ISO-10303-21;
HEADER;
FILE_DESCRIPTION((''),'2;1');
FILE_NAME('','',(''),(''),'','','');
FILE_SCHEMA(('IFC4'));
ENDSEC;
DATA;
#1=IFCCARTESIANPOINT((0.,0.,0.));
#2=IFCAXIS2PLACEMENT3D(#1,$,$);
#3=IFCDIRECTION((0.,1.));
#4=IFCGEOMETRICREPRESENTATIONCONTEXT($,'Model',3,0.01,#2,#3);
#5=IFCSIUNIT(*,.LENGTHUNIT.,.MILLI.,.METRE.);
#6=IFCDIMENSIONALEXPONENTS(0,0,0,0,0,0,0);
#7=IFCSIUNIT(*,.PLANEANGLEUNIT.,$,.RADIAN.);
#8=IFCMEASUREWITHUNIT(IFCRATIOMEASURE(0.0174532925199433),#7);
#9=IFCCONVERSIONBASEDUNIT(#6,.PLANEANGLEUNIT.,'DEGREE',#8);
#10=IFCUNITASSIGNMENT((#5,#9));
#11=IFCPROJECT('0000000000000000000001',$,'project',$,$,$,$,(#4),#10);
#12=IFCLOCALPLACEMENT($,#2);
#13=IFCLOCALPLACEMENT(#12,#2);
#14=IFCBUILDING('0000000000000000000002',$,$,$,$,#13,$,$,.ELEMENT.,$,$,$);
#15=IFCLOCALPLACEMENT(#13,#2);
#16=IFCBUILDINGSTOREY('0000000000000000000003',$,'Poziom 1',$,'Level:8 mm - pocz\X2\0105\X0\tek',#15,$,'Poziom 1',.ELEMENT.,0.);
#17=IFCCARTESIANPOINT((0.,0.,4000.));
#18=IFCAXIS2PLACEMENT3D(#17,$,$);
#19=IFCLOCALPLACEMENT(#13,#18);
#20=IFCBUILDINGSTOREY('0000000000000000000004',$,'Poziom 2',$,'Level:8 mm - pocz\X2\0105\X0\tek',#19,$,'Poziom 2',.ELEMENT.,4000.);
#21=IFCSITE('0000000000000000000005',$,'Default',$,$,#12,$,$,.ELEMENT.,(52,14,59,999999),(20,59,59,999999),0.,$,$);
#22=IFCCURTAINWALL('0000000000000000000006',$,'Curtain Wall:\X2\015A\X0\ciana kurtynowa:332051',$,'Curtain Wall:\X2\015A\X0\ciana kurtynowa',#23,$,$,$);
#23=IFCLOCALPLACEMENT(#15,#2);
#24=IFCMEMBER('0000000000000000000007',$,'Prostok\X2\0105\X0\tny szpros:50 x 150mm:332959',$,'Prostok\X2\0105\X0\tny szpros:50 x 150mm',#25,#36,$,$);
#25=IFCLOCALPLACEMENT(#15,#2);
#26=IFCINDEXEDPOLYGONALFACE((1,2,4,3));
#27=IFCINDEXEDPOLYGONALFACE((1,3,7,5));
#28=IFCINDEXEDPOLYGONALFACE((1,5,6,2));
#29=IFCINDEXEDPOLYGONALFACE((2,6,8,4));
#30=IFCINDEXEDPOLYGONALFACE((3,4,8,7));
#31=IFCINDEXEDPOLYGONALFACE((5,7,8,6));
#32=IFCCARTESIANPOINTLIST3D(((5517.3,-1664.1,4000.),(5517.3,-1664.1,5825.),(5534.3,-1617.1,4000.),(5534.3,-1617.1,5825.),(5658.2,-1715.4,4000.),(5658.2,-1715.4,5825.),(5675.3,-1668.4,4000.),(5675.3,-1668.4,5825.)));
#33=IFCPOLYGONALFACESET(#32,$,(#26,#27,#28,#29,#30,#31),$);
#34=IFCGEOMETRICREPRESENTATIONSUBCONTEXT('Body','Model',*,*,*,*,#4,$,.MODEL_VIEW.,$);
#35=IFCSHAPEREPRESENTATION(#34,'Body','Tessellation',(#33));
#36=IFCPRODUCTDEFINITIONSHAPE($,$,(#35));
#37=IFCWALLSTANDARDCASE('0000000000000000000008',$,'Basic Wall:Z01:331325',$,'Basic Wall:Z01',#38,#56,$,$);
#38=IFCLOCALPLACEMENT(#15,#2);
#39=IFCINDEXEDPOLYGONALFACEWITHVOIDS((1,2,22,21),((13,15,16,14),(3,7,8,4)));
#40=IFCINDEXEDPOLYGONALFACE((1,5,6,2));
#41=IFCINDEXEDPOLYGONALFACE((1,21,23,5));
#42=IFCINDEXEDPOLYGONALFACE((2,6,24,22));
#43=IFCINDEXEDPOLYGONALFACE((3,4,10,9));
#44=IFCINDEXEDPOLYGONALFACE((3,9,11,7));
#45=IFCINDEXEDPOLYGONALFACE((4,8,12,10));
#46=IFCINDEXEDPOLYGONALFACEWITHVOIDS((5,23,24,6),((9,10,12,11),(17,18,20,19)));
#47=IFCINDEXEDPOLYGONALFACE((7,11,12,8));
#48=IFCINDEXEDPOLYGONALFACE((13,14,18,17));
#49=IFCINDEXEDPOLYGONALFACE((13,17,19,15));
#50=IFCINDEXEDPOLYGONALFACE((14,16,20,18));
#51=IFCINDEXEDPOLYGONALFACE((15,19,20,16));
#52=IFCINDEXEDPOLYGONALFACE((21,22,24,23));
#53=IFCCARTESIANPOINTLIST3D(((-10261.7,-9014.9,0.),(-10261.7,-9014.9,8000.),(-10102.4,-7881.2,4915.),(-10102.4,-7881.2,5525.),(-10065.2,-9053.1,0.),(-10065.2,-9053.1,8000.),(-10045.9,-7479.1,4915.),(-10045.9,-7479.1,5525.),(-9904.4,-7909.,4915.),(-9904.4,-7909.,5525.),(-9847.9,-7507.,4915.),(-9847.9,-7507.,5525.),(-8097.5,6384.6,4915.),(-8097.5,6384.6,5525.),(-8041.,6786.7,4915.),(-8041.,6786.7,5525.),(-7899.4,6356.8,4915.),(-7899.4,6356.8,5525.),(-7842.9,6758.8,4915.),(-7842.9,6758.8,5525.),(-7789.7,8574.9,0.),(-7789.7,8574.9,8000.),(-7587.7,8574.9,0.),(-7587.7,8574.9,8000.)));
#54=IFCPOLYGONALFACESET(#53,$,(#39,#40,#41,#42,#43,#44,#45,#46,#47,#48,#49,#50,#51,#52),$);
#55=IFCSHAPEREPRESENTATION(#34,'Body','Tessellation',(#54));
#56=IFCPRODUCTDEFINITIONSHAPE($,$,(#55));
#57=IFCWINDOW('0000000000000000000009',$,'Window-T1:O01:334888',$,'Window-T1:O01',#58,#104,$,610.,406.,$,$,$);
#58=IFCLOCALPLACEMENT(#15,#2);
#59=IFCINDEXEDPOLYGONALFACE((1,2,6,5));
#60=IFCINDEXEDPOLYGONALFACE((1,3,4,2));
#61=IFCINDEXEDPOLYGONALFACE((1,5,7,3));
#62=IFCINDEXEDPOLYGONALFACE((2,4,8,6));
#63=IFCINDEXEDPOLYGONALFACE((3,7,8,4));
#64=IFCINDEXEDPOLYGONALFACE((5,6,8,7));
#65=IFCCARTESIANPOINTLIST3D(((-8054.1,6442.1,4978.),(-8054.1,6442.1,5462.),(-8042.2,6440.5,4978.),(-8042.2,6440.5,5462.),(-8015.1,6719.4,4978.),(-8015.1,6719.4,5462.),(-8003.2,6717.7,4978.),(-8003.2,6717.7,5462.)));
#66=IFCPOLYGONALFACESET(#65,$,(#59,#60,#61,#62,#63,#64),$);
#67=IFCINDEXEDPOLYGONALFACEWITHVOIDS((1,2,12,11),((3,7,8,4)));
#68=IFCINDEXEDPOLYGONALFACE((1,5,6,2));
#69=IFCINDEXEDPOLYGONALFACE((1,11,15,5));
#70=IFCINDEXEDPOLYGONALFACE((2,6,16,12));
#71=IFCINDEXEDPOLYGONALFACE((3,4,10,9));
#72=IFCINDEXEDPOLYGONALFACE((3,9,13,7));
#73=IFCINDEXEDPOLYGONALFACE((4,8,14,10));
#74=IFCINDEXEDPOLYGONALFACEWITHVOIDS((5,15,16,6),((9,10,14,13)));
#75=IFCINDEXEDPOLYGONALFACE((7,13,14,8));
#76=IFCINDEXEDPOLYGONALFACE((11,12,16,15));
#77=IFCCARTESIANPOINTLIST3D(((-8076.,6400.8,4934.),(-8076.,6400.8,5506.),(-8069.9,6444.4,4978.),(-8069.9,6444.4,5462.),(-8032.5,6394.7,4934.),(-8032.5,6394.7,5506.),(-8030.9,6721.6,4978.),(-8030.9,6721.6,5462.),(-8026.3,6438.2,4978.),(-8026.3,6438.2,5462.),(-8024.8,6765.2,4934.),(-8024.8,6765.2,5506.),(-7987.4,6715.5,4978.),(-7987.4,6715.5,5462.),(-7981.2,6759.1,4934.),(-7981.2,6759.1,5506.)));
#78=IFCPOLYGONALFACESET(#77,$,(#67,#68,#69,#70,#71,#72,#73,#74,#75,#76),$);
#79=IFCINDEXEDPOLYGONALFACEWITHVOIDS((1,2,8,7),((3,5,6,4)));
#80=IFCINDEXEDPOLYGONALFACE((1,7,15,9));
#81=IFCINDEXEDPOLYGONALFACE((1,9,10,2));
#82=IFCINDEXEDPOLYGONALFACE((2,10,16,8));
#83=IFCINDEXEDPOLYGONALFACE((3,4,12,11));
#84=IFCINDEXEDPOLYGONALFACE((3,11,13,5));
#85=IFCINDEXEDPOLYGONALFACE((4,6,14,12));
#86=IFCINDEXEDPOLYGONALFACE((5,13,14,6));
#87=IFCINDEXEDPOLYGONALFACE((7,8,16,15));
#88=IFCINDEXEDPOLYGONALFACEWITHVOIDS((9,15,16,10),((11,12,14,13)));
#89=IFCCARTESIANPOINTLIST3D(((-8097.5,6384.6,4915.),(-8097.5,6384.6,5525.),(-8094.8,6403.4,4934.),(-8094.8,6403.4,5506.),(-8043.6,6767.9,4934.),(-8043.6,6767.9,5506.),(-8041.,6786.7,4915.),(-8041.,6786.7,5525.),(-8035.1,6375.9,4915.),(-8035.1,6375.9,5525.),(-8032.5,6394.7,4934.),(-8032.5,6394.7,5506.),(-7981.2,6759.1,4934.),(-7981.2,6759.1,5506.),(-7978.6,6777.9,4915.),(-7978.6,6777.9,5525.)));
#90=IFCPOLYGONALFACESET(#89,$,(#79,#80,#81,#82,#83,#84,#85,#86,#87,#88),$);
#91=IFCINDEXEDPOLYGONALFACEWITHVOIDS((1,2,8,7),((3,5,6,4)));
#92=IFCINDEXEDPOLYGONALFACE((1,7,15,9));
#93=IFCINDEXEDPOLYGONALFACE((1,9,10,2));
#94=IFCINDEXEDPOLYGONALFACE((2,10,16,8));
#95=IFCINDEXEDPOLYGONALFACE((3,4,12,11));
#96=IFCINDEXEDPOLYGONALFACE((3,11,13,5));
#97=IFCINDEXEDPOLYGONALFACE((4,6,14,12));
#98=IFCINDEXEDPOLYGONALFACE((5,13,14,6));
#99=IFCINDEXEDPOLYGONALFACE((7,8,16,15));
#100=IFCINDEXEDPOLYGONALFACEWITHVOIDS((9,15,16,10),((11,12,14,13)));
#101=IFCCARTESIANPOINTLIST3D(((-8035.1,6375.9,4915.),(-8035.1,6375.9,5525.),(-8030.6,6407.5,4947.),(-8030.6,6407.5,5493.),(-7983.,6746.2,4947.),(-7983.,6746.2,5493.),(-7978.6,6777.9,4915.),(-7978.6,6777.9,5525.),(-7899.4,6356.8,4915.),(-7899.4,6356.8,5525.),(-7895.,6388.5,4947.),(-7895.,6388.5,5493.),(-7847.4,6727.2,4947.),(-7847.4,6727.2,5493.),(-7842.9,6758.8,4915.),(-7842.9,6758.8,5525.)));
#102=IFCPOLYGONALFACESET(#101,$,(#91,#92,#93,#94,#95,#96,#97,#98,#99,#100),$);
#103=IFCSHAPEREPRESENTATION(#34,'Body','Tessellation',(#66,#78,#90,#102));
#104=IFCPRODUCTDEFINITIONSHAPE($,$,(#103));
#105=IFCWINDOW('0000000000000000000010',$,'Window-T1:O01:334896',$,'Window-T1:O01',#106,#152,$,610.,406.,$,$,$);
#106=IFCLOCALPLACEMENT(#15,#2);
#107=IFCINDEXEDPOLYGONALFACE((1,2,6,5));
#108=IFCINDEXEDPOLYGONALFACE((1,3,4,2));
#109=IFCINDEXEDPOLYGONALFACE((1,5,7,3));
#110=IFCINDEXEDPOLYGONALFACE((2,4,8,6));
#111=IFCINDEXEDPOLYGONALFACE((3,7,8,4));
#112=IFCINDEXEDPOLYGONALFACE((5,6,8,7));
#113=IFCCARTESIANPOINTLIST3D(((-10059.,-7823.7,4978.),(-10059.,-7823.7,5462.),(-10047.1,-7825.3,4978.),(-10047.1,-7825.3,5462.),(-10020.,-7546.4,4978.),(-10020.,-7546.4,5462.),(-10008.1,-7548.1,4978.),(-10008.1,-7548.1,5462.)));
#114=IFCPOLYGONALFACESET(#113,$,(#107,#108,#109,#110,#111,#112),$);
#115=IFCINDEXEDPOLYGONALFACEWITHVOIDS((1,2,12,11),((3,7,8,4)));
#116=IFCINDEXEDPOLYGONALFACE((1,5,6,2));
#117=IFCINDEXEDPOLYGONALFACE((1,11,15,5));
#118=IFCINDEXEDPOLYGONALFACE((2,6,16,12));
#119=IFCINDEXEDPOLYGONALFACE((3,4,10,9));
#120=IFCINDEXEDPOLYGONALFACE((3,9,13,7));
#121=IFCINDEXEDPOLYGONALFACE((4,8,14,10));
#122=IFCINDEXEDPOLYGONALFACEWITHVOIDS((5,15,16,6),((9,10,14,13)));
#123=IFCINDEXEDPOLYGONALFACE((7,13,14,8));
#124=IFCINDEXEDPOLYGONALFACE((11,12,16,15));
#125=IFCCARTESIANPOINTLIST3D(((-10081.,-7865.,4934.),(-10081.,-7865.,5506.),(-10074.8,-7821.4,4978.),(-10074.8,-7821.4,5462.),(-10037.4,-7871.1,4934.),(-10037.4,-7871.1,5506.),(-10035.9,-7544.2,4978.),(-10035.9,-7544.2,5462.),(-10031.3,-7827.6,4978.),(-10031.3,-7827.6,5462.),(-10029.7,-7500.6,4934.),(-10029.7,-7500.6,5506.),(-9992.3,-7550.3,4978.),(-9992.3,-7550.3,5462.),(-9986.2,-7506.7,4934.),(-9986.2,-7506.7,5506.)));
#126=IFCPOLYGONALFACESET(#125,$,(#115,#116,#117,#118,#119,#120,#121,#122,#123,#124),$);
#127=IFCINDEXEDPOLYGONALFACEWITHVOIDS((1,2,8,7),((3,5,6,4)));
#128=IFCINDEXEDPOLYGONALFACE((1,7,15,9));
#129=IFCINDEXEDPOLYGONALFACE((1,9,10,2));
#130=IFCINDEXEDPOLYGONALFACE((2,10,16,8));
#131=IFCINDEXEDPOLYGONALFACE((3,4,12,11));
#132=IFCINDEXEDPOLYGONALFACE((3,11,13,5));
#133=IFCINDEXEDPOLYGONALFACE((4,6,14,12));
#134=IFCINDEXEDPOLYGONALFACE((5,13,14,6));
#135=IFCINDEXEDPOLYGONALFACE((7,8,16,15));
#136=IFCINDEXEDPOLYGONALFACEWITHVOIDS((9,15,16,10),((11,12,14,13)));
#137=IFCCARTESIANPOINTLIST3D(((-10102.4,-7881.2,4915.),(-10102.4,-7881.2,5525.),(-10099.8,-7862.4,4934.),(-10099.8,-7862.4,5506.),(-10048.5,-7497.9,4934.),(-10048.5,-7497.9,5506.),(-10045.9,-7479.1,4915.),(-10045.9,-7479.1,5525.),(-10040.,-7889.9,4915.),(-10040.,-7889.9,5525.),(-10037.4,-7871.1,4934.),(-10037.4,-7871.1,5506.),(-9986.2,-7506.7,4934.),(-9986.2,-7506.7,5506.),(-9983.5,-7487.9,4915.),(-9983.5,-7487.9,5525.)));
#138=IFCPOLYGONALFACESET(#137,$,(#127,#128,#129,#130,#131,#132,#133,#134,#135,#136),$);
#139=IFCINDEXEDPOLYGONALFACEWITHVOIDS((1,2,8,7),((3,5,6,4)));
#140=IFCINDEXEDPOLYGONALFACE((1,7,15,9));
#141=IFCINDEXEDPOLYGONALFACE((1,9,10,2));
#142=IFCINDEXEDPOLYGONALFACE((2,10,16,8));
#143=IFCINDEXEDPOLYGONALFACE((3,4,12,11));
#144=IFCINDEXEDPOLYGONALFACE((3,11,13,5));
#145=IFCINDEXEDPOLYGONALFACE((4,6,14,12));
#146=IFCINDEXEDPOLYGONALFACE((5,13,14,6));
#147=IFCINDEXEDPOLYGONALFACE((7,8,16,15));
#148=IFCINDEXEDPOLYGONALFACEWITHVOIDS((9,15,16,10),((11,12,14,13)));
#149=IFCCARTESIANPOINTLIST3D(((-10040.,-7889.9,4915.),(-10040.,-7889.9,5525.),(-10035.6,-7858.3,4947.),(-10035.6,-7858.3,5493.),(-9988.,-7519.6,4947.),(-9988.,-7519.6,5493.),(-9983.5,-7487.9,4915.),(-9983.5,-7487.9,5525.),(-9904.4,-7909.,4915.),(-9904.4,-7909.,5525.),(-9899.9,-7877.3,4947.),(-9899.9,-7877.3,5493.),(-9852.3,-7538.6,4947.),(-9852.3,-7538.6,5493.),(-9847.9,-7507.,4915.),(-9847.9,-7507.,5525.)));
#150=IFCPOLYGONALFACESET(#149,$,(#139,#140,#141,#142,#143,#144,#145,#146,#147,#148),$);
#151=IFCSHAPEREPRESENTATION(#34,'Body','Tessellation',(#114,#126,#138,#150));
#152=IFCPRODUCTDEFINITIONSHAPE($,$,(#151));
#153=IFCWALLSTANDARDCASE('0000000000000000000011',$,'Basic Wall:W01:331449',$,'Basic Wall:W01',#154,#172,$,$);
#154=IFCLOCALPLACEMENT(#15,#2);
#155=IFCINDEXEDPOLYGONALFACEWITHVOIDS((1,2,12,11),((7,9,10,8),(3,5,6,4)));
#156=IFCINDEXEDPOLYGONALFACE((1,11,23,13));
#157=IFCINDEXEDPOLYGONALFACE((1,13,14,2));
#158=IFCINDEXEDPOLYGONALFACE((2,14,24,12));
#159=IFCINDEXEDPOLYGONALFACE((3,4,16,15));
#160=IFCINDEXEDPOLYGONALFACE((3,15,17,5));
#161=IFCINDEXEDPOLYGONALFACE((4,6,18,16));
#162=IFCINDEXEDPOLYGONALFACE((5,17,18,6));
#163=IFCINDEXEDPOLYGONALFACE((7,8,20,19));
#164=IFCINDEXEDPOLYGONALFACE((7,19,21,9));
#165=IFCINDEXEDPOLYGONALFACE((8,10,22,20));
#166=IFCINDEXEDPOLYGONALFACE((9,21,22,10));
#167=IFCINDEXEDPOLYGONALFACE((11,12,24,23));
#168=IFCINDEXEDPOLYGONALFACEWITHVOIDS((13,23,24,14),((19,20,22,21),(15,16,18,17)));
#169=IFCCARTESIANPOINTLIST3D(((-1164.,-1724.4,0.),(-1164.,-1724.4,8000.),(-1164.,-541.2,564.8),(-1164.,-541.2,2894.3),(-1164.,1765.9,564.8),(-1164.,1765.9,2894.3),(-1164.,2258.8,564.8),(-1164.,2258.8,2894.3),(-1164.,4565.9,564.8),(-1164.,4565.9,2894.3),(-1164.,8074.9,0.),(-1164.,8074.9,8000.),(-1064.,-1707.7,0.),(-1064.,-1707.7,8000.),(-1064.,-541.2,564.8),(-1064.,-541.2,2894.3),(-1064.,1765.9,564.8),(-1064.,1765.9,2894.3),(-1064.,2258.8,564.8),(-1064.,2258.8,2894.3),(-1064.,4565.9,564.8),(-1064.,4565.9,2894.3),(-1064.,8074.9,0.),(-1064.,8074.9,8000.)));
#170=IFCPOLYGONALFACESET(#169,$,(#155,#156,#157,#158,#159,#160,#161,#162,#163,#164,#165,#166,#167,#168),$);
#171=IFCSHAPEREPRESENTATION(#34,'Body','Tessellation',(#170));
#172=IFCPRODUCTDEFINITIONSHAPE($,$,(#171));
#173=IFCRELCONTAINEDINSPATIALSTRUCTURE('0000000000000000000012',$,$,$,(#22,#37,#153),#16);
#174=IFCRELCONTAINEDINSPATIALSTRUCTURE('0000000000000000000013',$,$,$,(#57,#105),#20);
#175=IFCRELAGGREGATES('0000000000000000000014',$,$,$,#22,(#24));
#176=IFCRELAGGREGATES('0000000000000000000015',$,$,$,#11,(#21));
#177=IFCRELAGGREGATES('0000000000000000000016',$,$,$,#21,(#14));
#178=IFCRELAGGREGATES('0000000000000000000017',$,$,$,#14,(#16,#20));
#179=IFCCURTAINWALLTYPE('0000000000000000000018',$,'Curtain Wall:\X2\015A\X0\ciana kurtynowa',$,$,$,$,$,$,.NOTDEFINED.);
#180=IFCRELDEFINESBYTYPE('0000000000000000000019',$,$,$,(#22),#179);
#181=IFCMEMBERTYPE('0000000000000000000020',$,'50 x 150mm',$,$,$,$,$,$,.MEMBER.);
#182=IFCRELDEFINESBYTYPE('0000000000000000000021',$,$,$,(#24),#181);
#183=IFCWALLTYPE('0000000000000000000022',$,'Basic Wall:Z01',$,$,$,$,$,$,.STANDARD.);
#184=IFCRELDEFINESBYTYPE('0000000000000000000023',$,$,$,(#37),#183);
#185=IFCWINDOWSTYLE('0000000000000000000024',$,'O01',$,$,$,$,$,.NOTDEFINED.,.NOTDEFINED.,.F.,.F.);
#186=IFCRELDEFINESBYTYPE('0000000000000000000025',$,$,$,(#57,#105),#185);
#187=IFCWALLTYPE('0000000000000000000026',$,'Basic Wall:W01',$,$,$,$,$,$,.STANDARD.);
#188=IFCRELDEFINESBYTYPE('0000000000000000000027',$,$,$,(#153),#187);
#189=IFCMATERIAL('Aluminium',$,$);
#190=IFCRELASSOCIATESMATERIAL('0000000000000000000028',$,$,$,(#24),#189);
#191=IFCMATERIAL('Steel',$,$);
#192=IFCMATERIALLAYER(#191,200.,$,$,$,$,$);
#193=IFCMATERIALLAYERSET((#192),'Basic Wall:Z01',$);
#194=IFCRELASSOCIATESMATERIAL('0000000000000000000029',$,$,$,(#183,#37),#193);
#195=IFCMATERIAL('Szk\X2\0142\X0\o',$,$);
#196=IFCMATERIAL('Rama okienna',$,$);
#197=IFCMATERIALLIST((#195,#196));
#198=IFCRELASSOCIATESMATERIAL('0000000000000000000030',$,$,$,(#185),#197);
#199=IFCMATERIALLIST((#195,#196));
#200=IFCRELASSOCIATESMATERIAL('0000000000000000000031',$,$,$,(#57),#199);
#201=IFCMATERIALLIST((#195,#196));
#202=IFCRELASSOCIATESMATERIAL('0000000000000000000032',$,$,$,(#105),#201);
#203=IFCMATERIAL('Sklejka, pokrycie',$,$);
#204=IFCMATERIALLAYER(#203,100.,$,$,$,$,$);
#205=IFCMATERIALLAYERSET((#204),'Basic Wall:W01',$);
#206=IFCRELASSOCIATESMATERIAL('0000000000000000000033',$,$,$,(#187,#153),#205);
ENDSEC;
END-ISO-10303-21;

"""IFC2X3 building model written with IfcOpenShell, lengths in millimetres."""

from ifc_helpers import new_model, entity, si_unit, converted_unit, direction, frame, frame_2d, origin, origin_2d_with_axis, place, context, subcontext, project, spatial, polyline, rectangle, outline, extrude, source, transform, mapped, material, material_list, layer, layer_set, layer_usage, type_object, type_shapes, element, fill, aggregate, save


model = new_model("IFC2X3")

# Units and contexts
model_context = context("Model", 3, precision=0.01, world=origin(), true_north=direction((0.0, 1.0)))
body_context = subcontext(model_context, "Body", "Model", "MODEL_VIEW")
ifc_project = project(units=[si_unit("LENGTHUNIT", "METRE", prefix="MILLI"), converted_unit("PLANEANGLEUNIT", "DEGREE", entity("IfcRatioMeasure", 0.0174532925199433), si_unit("PLANEANGLEUNIT", "RADIAN"), dimensions=[0, 0, 0, 0, 0, 0, 0])], contexts=[model_context])

# Site, building, storey
site_placement = place(None, origin())
site = spatial("IfcSite", under=ifc_project, at=site_placement, Name="Default", CompositionType="ELEMENT", RefLatitude=(52, 14, 59, 999999), RefLongitude=(20, 59, 59, 999999), RefElevation=0.0)
building_placement = place(site_placement, origin())
building = spatial("IfcBuilding", under=site, at=building_placement, CompositionType="ELEMENT")
storey_1_placement = place(building_placement, origin())
storey_1 = spatial("IfcBuildingStorey", under=building, at=storey_1_placement, Name="Poziom 1", ObjectType="Level:8 mm - początek", LongName="Poziom 1", CompositionType="ELEMENT", Elevation=0.0)

# Curtain wall, member
curtain_wall_type = type_object("IfcCurtainWallType", Name="Curtain Wall:Ściana kurtynowa", PredefinedType="NOTDEFINED")
curtain_wall_placement = place(storey_1_placement, origin())
curtain_wall = element("IfcCurtainWall", 1, at=curtain_wall_placement, inside=storey_1, type_object=curtain_wall_type, Name="Curtain Wall:Ściana kurtynowa:332051", ObjectType="Curtain Wall:Ściana kurtynowa")
ifc_material_1 = material(Name="Aluminium")
member_type_1 = type_object("IfcMemberType", Name="50 x 150mm", PredefinedType="MEMBER")
shared_shape_1 = source(origin(), body_context, "Body", "SweptSolid", [
    extrude(rectangle(XDim=150.0, YDim=50.0, at=origin_2d_with_axis()), frame((0.0, 0.0, -1825.0), z_axis=(0.0, 0.0, 1.0), x_axis=(0.0, -1.0, 0.0)), (0.0, 0.0, 1.0), 1825.0),
])
type_shapes(member_type_1, [shared_shape_1])
member_1_placement = place(storey_1_placement, frame((5596.3, -1666.3, 4000.0), z_axis=(0.0, 0.0, -1.0), x_axis=(0.341586, 0.939851, 0.0)))
member_1 = element("IfcMember", 2, at=member_1_placement, type_object=member_type_1, material=ifc_material_1, Name="Prostokątny szpros:50 x 150mm:332959", ObjectType="Prostokątny szpros:50 x 150mm", context=body_context, shape_type="MappedRepresentation", body=[
    mapped(shared_shape_1, transform((0.0, 0.0, 0.0), scale=1.0)),
])

aggregate(curtain_wall, [member_1])

# Wall, openings
ifc_material_2 = material(Name="Steel")
ifc_layer_1 = layer(ifc_material_2, 200.0)
ifc_layer_set_1 = layer_set([ifc_layer_1], Name="Basic Wall:Z01")
ifc_layer_usage_1 = layer_usage(ifc_layer_set_1, "AXIS2", "NEGATIVE", 100.0)
wall_type_1 = type_object("IfcWallType", Name="Basic Wall:Z01", PredefinedType="STANDARD", material=ifc_layer_set_1)
wall_1_placement = place(storey_1_placement, frame((-7686.7, 8588.8, 0.0), z_axis=(0.0, 0.0, 1.0), x_axis=(-0.139173, -0.990268, 0.0)))
wall_1 = element("IfcWallStandardCase", 3, at=wall_1_placement, inside=storey_1, type_object=wall_type_1, material=ifc_layer_usage_1, Name="Basic Wall:Z01:331325", ObjectType="Basic Wall:Z01", context=body_context, shape_type="SweptSolid", body=[
    extrude(outline(polyline([(17790.8, -100.0), (17801.2, 100.0), (17300.6, 100.0), (504.9, 100.0), (0.0, 100.0), (28.1, -100.0), (17790.8, -100.0)])), origin(), (0.0, 0.0, 1.0), 8000.0),
])
opening_1_placement = place(wall_1_placement, frame((2239.9, 100.0, 4915.0)))
opening_1 = element("IfcOpeningElement", 4, at=opening_1_placement, cuts=wall_1, ObjectType="Opening", context=body_context, shape_type="SweptSolid", body=[
    extrude(rectangle(XDim=610.0, YDim=406.0, at=frame_2d((305.0, 203.0), x_axis=(1.0, 0.0))), frame((0.0, 0.0, 0.0), z_axis=(0.0, -1.0, 0.0), x_axis=(0.0, 0.0, 1.0)), (0.0, 0.0, 1.0), 200.0),
])
opening_2_placement = place(wall_1_placement, frame((16645.9, 100.0, 4915.0)))
opening_2 = element("IfcOpeningElement", 5, at=opening_2_placement, cuts=wall_1, ObjectType="Opening", context=body_context, shape_type="SweptSolid", body=[
    extrude(rectangle(XDim=610.0, YDim=406.0, at=frame_2d((305.0, 203.0), x_axis=(1.0, 0.0))), frame((0.0, 0.0, 0.0), z_axis=(0.0, -1.0, 0.0), x_axis=(0.0, 0.0, 1.0)), (0.0, 0.0, 1.0), 200.0),
])

# Shared definitions
storey_2_placement = place(building_placement, frame((0.0, 0.0, 4000.0)))
storey_2 = spatial("IfcBuildingStorey", under=building, at=storey_2_placement, Name="Poziom 2", ObjectType="Level:8 mm - początek", LongName="Poziom 2", CompositionType="ELEMENT", Elevation=4000.0)

# Windows
ifc_material_3 = material(Name="Szkło")
ifc_material_4 = material(Name="Rama okienna")
ifc_material_list_1 = material_list([ifc_material_3, ifc_material_4])
ifc_material_list_2 = material_list([ifc_material_3, ifc_material_4])
window_style = type_object("IfcWindowStyle", Name="O01", ConstructionType="NOTDEFINED", OperationType="NOTDEFINED", ParameterTakesPrecedence=False, Sizeable=False, material=ifc_material_list_2)
shared_shape_2 = source(origin(), body_context, "Body", "SweptSolid", [
    extrude(rectangle(XDim=12.0, YDim=280.0, at=frame_2d((0.0, 0.0), x_axis=(1.0, 0.0))), frame((203.0, 159.0, 63.0), z_axis=(0.0, 0.0, 1.0), x_axis=(0.0, -1.0, 0.0)), (0.0, 0.0, 1.0), 484.0),
    extrude(outline(polyline([(-184.0, -286.0), (184.0, -286.0), (184.0, 286.0), (-184.0, 286.0), (-184.0, -286.0)]), holes=[polyline([(-140.0, -242.0), (-140.0, 242.0), (140.0, 242.0), (140.0, -242.0), (-140.0, -242.0)])]), frame((203.0, 137.0, 305.0), z_axis=(0.0, 1.0, 0.0), x_axis=(1.0, 0.0, 0.0)), (0.0, 0.0, 1.0), 44.0),
    extrude(outline(polyline([(-203.0, -305.0), (203.0, -305.0), (203.0, 305.0), (-203.0, 305.0), (-203.0, -305.0)]), holes=[polyline([(-184.0, -286.0), (-184.0, 286.0), (184.0, 286.0), (184.0, -286.0), (-184.0, -286.0)])]), frame((203.0, 137.0, 305.0), z_axis=(0.0, 1.0, 0.0), x_axis=(1.0, 0.0, 0.0)), (0.0, 0.0, 1.0), 63.0),
    extrude(outline(polyline([(-203.0, -305.0), (203.0, -305.0), (203.0, 305.0), (-203.0, 305.0), (-203.0, -305.0)]), holes=[polyline([(-171.0, -273.0), (-171.0, 273.0), (171.0, 273.0), (171.0, -273.0), (-171.0, -273.0)])]), frame((203.0, 0.0, 305.0), z_axis=(0.0, 1.0, 0.0), x_axis=(1.0, 0.0, 0.0)), (0.0, 0.0, 1.0), 137.0),
])
type_shapes(window_style, [shared_shape_2])
window_1_placement = place(opening_1_placement, frame((0.0, 0.0, 0.0), z_axis=(0.0, 0.0, 1.0), x_axis=(-1.0, 0.0, 0.0)))
window_1 = element("IfcWindow", 6, at=window_1_placement, inside=storey_2, type_object=window_style, material=ifc_material_list_1, Name="Window-T1:O01:334888", ObjectType="Window-T1:O01", OverallHeight=610.0, OverallWidth=406.0, context=body_context, shape_type="MappedRepresentation", body=[
    mapped(shared_shape_2, transform((0.0, 0.0, 0.0), scale=1.0)),
])
fill(opening_1, window_1)
ifc_material_list_3 = material_list([ifc_material_3, ifc_material_4])
window_2_placement = place(opening_2_placement, frame((0.0, 0.0, 0.0), z_axis=(0.0, 0.0, 1.0), x_axis=(-1.0, 0.0, 0.0)))
window_2 = element("IfcWindow", 7, at=window_2_placement, inside=storey_2, type_object=window_style, material=ifc_material_list_3, Name="Window-T1:O01:334896", ObjectType="Window-T1:O01", OverallHeight=610.0, OverallWidth=406.0, context=body_context, shape_type="MappedRepresentation", body=[
    mapped(shared_shape_2, transform((0.0, 0.0, 0.0), scale=1.0)),
])
fill(opening_2, window_2)

# Wall, openings
ifc_material_5 = material(Name="Sklejka, pokrycie")
ifc_layer_2 = layer(ifc_material_5, 100.0)
ifc_layer_set_2 = layer_set([ifc_layer_2], Name="Basic Wall:W01")
ifc_layer_usage_2 = layer_usage(ifc_layer_set_2, "AXIS2", "NEGATIVE", 50.0)
wall_type_2 = type_object("IfcWallType", Name="Basic Wall:W01", PredefinedType="STANDARD", material=ifc_layer_set_2)
wall_2_placement = place(storey_1_placement, frame((-1114.0, -1724.4, 0.0), z_axis=(0.0, 0.0, 1.0), x_axis=(0.0, 1.0, 0.0)))
wall_2 = element("IfcWallStandardCase", 8, at=wall_2_placement, inside=storey_1, type_object=wall_type_2, material=ifc_layer_usage_2, Name="Basic Wall:W01:331449", ObjectType="Basic Wall:W01", context=body_context, shape_type="SweptSolid", body=[
    extrude(outline(polyline([(9799.3, -50.0), (9799.3, 50.0), (0.0, 50.0), (16.7, -50.0), (9799.3, -50.0)])), origin(), (0.0, 0.0, 1.0), 8000.0),
])
opening_3_placement = place(wall_2_placement, origin())
element("IfcOpeningElement", 9, at=opening_3_placement, cuts=wall_2, ObjectType="Opening", context=body_context, shape_type="SweptSolid", body=[
    extrude(rectangle(XDim=2329.5, YDim=2307.1, at=origin_2d_with_axis()), frame((2336.8, -50.0, 1729.5), z_axis=(0.0, 1.0, 0.0), x_axis=(0.0, 0.0, -1.0)), (0.0, 0.0, 1.0), 100.0),
])
opening_4_placement = place(wall_2_placement, origin())
element("IfcOpeningElement", 10, at=opening_4_placement, cuts=wall_2, ObjectType="Opening", context=body_context, shape_type="SweptSolid", body=[
    extrude(rectangle(XDim=2329.5, YDim=2307.1, at=origin_2d_with_axis()), frame((5136.8, -50.0, 1729.5), z_axis=(0.0, 1.0, 0.0), x_axis=(0.0, 0.0, -1.0)), (0.0, 0.0, 1.0), 100.0),
])

save(model, "model.ifc")
